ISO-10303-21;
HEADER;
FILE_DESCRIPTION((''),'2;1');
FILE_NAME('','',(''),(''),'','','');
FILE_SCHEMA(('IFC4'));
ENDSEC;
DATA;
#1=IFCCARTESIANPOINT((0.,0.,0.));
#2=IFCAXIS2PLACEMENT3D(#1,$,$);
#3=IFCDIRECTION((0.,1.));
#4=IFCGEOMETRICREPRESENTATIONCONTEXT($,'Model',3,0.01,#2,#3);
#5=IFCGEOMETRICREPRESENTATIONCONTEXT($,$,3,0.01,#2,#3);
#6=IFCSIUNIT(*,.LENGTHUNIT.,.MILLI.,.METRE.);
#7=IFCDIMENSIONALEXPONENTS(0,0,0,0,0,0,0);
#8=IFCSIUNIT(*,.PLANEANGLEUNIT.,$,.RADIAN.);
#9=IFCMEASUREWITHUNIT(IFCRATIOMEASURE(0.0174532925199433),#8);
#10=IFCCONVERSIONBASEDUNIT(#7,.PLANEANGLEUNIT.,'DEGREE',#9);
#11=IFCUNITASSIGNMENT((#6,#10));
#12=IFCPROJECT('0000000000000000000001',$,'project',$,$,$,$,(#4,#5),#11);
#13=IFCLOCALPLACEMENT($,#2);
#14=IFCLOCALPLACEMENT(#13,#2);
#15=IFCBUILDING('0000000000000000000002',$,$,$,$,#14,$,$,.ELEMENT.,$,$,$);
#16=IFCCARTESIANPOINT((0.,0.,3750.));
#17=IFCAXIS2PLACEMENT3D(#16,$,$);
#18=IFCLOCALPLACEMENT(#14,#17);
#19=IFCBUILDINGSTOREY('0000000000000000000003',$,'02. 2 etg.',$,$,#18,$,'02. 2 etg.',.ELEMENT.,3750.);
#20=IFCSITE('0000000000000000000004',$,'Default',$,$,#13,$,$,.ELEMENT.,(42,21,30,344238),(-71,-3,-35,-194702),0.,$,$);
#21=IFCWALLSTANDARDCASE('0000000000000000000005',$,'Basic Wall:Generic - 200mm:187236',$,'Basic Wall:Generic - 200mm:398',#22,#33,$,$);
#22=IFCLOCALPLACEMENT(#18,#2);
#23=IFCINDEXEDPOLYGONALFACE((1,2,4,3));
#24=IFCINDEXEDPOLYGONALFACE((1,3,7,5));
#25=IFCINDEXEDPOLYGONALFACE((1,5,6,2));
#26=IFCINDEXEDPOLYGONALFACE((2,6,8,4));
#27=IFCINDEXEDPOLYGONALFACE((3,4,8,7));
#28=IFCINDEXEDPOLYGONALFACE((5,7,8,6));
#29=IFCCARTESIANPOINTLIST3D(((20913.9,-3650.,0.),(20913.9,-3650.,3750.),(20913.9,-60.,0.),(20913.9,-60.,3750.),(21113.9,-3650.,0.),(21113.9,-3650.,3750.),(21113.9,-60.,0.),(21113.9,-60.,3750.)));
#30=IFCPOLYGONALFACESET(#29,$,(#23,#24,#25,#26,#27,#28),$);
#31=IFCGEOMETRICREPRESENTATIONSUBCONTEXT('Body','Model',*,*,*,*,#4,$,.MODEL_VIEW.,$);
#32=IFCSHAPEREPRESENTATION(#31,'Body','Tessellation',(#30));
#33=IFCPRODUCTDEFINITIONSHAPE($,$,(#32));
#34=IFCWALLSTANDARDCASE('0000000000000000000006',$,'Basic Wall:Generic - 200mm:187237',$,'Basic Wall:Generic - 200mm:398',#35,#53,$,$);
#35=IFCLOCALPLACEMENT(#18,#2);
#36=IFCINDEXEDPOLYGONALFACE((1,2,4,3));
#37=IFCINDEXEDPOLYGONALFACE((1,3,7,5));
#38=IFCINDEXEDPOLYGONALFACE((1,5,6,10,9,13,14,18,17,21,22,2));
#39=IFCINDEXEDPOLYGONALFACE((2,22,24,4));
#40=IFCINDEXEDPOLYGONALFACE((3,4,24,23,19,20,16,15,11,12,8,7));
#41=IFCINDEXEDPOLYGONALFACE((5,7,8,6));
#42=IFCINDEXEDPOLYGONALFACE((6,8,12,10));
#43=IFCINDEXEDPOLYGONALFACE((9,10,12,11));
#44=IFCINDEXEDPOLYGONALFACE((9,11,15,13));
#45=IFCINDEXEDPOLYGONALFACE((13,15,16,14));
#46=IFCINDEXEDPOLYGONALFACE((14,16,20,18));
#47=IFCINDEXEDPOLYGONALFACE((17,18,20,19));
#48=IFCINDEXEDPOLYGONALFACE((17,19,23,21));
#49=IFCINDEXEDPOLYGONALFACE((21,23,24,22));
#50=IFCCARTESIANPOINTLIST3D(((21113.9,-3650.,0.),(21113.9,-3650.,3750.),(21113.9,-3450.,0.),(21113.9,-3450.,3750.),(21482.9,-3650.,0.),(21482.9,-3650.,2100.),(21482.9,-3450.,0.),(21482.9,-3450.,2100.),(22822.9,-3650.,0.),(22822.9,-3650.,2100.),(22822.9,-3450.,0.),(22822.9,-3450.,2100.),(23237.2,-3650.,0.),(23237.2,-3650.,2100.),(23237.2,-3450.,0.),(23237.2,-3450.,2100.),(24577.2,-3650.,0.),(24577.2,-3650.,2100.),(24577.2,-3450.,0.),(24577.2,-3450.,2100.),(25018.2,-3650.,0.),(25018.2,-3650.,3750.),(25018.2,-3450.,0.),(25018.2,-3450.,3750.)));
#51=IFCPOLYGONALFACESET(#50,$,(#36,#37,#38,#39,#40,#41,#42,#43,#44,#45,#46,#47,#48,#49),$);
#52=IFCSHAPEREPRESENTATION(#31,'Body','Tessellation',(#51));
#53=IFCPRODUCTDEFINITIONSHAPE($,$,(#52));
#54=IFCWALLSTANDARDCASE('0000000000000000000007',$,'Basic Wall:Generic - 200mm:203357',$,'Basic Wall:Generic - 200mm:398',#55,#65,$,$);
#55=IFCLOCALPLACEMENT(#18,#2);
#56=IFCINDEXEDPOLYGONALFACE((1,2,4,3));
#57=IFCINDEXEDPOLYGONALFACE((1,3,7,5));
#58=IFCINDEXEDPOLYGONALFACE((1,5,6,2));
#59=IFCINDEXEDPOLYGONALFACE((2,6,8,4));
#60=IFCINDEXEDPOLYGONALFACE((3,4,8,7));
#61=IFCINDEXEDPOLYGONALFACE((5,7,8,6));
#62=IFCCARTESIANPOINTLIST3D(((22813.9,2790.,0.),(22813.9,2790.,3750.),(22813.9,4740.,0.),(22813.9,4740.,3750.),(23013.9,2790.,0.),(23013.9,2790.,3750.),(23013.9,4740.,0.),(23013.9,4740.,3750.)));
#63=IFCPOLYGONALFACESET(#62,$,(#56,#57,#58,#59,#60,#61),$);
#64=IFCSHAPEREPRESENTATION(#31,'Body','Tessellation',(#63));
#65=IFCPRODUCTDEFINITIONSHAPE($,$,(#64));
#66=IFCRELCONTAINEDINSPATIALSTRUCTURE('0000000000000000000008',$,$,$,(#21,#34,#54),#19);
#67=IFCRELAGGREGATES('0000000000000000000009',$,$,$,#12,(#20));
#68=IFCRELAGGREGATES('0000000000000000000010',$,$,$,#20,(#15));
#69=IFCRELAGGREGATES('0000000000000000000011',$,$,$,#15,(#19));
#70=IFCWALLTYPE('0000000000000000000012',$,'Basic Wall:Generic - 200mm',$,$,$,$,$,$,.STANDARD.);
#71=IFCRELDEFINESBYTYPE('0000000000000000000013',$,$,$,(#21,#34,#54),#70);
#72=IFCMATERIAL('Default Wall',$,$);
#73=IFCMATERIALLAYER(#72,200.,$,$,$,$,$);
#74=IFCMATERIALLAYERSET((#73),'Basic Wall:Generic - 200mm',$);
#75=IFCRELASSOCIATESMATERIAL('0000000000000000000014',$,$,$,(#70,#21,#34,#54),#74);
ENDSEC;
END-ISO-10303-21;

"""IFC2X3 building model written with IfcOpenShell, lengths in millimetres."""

from ifc_helpers import new_model, entity, si_unit, converted_unit, direction, frame, frame_2d, origin, place, context, subcontext, project, spatial, rectangle, extrude, clip, halfspace, material, layer, layer_set, layer_usage, type_object, element, save


model = new_model("IFC2X3")

# Units and contexts
model_context = context("Model", 3, precision=0.01, world=origin(), true_north=direction((0.0, 1.0)))
context_of_model = context(None, 3, precision=0.01, world=origin(), true_north=direction((0.0, 1.0)))
body_context = subcontext(model_context, "Body", "Model", "MODEL_VIEW")
ifc_project = project(units=[si_unit("LENGTHUNIT", "METRE", prefix="MILLI"), converted_unit("PLANEANGLEUNIT", "DEGREE", entity("IfcRatioMeasure", 0.0174532925199433), si_unit("PLANEANGLEUNIT", "RADIAN"), dimensions=[0, 0, 0, 0, 0, 0, 0])], contexts=[model_context, context_of_model])

# Site, building, storey
site_placement = place(None, origin())
site = spatial("IfcSite", under=ifc_project, at=site_placement, Name="Default", CompositionType="ELEMENT", RefLatitude=(42, 21, 30, 344238), RefLongitude=(-71, -3, -35, -194702), RefElevation=0.0)
building_placement = place(site_placement, origin())
building = spatial("IfcBuilding", under=site, at=building_placement, CompositionType="ELEMENT")
storey_placement = place(building_placement, frame((0.0, 0.0, 3750.0)))
storey = spatial("IfcBuildingStorey", under=building, at=storey_placement, Name="02. 2 etg.", LongName="02. 2 etg.", CompositionType="ELEMENT", Elevation=3750.0)

# Wall
ifc_material_1 = material(Name="Default Wall")
ifc_layer_1 = layer(ifc_material_1, 200.0)
ifc_layer_set_1 = layer_set([ifc_layer_1], Name="Basic Wall:Generic - 200mm")
ifc_layer_usage_1 = layer_usage(ifc_layer_set_1, "AXIS2", "NEGATIVE", 100.0)
wall_type_1 = type_object("IfcWallType", Name="Basic Wall:Generic - 200mm", PredefinedType="STANDARD", material=ifc_layer_set_1)
wall_1_placement = place(storey_placement, frame((21013.9, -60.0, 0.0), z_axis=(0.0, 0.0, 1.0), x_axis=(0.0, -1.0, 0.0)))
element("IfcWallStandardCase", 1, at=wall_1_placement, inside=storey, type_object=wall_type_1, material=ifc_layer_usage_1, Name="Basic Wall:Generic - 200mm:187236", ObjectType="Basic Wall:Generic - 200mm:398", context=body_context, shape_type="SweptSolid", body=[
    extrude(rectangle(XDim=3590.0, YDim=200.0, at=frame_2d((1795.0, 0.0), x_axis=(-1.0, 0.0))), origin(), (0.0, 0.0, 1.0), 3750.0),
])

# Wall, openings
ifc_layer_usage_2 = layer_usage(ifc_layer_set_1, "AXIS2", "NEGATIVE", 100.0)
wall_2_placement = place(storey_placement, frame((21113.9, -3550.0, 0.0)))
wall_2 = element("IfcWallStandardCase", 2, at=wall_2_placement, inside=storey, type_object=wall_type_1, material=ifc_layer_usage_2, Name="Basic Wall:Generic - 200mm:187237", ObjectType="Basic Wall:Generic - 200mm:398", context=body_context, shape_type="SweptSolid", body=[
    extrude(rectangle(XDim=3904.3, YDim=200.0, at=frame_2d((1952.2, 0.0), x_axis=(-1.0, 0.0))), origin(), (0.0, 0.0, 1.0), 3750.0),
])
opening_1_placement = place(wall_2_placement, frame((2123.3, -1624.0, 0.0)))
element("IfcOpeningElement", 3, at=opening_1_placement, cuts=wall_2, ObjectType="Opening", context=body_context, shape_type="SweptSolid", body=[
    extrude(rectangle(XDim=2100.0, YDim=1340.0, at=frame_2d((0.0, 0.0), x_axis=(1.0, 0.0))), frame((670.0, 0.0, 1050.0), z_axis=(0.0, 1.0, 0.0), x_axis=(0.0, 0.0, -1.0)), (0.0, 0.0, 1.0), 3048.0),
])
opening_2_placement = place(wall_2_placement, frame((369.0, -1624.0, 0.0)))
element("IfcOpeningElement", 4, at=opening_2_placement, cuts=wall_2, ObjectType="Opening", context=body_context, shape_type="SweptSolid", body=[
    extrude(rectangle(XDim=2100.0, YDim=1340.0, at=frame_2d((0.0, 0.0), x_axis=(1.0, 0.0))), frame((670.0, 0.0, 1050.0), z_axis=(0.0, 1.0, 0.0), x_axis=(0.0, 0.0, -1.0)), (0.0, 0.0, 1.0), 3048.0),
])

# Wall
ifc_layer_usage_3 = layer_usage(ifc_layer_set_1, "AXIS2", "NEGATIVE", 100.0)
wall_3_placement = place(storey_placement, frame((22913.9, 4740.0, 0.0), z_axis=(0.0, 0.0, 1.0), x_axis=(0.0, -1.0, 0.0)))
element("IfcWallStandardCase", 5, at=wall_3_placement, inside=storey, type_object=wall_type_1, material=ifc_layer_usage_3, Name="Basic Wall:Generic - 200mm:203357", ObjectType="Basic Wall:Generic - 200mm:398", context=body_context, shape_type="Clipping", body=[
    clip(extrude(rectangle(XDim=1950.0, YDim=200.0, at=frame_2d((975.0, 0.0), x_axis=(-1.0, 0.0))), origin(), (0.0, 0.0, 1.0), 3750.0), halfspace(origin(), True)),
])

save(model, "model.ifc")
